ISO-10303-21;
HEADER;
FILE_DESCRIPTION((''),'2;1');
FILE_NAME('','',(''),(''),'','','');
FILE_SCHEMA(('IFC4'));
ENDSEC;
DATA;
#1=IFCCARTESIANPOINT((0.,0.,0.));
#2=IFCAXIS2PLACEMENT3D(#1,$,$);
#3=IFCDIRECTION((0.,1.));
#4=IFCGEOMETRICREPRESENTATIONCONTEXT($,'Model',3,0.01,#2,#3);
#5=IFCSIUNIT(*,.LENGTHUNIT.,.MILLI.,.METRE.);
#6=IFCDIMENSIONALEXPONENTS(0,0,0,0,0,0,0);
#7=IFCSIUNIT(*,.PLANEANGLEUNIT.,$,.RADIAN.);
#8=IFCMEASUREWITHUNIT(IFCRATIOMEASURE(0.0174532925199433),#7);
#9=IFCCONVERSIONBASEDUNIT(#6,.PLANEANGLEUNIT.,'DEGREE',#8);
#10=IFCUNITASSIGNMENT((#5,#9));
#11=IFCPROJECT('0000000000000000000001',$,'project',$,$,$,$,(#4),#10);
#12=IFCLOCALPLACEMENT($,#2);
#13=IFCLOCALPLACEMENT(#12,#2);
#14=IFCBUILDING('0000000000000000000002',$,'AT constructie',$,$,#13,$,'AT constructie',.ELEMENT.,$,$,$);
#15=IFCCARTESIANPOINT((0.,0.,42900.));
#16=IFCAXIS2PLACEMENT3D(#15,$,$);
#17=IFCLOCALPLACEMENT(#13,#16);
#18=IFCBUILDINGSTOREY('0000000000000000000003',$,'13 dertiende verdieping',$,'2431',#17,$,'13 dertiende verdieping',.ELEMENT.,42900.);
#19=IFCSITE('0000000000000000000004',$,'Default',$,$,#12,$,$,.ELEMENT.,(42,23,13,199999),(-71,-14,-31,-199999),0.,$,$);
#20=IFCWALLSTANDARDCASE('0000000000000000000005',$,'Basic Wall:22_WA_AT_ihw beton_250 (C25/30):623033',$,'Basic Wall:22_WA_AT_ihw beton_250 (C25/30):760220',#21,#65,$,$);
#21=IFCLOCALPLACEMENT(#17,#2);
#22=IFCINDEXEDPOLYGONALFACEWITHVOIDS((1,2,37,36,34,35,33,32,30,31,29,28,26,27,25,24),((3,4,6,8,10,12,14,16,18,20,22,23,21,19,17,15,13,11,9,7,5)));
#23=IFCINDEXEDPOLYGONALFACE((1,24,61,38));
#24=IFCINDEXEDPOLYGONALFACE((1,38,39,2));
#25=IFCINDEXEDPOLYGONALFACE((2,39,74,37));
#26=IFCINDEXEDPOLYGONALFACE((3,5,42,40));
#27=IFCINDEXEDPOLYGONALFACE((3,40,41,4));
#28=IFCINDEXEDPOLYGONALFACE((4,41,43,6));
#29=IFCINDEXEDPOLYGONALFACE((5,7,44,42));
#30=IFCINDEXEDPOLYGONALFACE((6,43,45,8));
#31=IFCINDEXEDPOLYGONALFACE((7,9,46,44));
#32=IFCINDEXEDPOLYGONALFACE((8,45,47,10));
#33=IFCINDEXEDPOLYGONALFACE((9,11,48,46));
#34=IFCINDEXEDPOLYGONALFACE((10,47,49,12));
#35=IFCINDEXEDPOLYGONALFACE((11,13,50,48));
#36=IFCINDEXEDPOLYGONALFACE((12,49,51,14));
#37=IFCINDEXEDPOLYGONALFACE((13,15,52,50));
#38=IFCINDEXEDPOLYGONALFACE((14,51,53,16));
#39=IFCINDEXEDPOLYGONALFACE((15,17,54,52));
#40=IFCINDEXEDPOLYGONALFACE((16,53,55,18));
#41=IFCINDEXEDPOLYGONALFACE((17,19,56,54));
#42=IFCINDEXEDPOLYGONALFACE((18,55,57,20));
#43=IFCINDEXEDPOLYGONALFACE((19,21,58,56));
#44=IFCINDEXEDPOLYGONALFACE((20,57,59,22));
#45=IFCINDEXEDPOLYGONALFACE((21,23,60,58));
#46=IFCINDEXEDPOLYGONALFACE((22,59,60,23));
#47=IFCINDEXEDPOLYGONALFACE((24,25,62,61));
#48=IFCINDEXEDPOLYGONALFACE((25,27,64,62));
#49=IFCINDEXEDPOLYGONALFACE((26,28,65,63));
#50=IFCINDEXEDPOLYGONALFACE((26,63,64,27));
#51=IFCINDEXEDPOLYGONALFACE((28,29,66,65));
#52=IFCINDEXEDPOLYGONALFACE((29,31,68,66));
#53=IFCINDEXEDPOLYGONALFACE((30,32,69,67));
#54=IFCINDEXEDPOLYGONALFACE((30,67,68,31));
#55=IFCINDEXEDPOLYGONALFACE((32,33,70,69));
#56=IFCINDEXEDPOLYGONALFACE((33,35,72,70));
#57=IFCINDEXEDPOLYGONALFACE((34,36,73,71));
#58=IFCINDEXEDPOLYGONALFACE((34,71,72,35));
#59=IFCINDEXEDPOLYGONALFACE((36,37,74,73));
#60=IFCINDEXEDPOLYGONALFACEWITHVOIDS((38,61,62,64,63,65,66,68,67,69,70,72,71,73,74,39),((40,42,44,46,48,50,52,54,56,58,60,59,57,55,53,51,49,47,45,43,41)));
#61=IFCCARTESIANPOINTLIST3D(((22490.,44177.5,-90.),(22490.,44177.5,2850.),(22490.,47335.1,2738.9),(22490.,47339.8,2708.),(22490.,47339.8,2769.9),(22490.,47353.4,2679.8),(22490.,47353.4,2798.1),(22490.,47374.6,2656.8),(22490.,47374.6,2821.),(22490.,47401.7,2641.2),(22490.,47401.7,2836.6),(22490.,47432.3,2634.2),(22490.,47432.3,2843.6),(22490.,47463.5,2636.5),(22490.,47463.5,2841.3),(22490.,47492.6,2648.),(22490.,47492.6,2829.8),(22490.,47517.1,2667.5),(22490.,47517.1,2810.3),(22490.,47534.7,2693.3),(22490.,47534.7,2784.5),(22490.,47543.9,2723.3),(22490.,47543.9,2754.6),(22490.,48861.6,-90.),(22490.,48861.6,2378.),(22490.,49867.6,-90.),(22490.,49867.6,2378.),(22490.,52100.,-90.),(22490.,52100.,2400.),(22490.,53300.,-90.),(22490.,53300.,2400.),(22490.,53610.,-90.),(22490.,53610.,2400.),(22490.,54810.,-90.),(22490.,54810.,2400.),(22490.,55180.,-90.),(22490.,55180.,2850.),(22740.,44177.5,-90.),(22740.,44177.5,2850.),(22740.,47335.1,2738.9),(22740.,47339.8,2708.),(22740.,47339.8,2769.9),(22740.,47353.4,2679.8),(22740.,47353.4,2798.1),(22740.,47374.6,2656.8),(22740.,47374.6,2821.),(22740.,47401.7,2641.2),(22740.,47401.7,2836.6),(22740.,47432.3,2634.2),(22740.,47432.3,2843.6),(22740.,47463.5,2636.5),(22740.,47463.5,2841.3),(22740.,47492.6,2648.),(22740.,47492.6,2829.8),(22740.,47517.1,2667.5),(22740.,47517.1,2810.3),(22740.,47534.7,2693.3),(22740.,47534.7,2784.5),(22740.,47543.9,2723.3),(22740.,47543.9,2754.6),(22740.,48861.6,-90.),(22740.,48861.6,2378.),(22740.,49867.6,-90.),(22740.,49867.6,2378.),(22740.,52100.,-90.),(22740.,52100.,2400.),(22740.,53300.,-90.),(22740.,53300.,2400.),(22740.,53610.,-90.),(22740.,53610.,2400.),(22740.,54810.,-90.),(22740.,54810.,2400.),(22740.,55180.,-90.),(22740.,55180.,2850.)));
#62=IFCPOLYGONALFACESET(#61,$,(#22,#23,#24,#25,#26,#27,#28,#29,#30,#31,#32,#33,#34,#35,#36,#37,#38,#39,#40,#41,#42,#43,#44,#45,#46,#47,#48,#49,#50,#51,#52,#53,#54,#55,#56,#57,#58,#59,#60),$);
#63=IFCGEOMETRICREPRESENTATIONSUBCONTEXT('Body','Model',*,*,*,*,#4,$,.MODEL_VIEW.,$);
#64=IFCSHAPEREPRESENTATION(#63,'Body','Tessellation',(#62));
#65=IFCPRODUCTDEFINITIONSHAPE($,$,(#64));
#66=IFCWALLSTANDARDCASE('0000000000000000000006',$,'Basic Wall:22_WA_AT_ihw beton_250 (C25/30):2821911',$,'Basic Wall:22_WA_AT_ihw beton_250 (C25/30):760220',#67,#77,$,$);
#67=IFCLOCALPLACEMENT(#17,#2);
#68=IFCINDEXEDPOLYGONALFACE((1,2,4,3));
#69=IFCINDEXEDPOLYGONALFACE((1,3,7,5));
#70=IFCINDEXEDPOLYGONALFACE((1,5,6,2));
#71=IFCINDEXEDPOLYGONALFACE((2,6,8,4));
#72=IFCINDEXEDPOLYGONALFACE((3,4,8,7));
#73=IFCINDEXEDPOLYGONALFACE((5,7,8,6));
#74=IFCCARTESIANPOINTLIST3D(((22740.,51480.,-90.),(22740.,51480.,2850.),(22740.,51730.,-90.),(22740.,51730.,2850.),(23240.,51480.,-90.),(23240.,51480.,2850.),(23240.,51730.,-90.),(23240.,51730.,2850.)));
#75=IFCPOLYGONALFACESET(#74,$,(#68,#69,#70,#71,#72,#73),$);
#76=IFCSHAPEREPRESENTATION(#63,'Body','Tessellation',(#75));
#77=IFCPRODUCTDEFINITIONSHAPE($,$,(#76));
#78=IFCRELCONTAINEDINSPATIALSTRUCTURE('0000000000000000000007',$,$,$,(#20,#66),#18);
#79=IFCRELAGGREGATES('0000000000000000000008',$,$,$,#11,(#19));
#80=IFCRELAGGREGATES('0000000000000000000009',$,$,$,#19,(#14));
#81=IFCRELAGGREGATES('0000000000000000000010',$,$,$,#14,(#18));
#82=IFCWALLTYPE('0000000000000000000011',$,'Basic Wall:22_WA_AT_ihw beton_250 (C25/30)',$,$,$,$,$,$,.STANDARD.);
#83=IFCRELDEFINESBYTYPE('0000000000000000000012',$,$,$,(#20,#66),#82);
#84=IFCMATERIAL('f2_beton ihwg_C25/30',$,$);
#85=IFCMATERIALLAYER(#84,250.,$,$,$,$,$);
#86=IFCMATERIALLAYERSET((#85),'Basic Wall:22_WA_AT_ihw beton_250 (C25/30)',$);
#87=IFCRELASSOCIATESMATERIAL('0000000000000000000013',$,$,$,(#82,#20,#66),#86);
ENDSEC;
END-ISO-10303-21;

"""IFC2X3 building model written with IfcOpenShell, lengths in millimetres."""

from ifc_helpers import new_model, entity, si_unit, converted_unit, direction, frame, frame_2d, origin, origin_2d_with_axis, place, context, subcontext, project, spatial, rectangle, circle, extrude, material, layer, layer_set, layer_usage, type_object, element, save


model = new_model("IFC2X3")

# Units and contexts
model_context = context("Model", 3, precision=0.01, world=origin(), true_north=direction((0.0, 1.0)))
body_context = subcontext(model_context, "Body", "Model", "MODEL_VIEW")
ifc_project = project(units=[si_unit("LENGTHUNIT", "METRE", prefix="MILLI"), converted_unit("PLANEANGLEUNIT", "DEGREE", entity("IfcRatioMeasure", 0.0174532925199433), si_unit("PLANEANGLEUNIT", "RADIAN"), dimensions=[0, 0, 0, 0, 0, 0, 0])], contexts=[model_context])

# Site, building, storey
site_placement = place(None, origin())
site = spatial("IfcSite", under=ifc_project, at=site_placement, Name="Default", CompositionType="ELEMENT", RefLatitude=(42, 23, 13, 199999), RefLongitude=(-71, -14, -31, -199999), RefElevation=0.0)
building_placement = place(site_placement, origin())
building = spatial("IfcBuilding", under=site, at=building_placement, Name="AT constructie", LongName="AT constructie", CompositionType="ELEMENT")
storey_placement = place(building_placement, frame((0.0, 0.0, 42900.0)))
storey = spatial("IfcBuildingStorey", under=building, at=storey_placement, Name="13 dertiende verdieping", ObjectType="2431", LongName="13 dertiende verdieping", CompositionType="ELEMENT", Elevation=42900.0)

# Shared definitions
ifc_material_1 = material(Name="f2_beton ihwg_C25/30")

# Wall, openings
ifc_layer_1 = layer(ifc_material_1, 250.0)
ifc_layer_set_1 = layer_set([ifc_layer_1], Name="Basic Wall:22_WA_AT_ihw beton_250 (C25/30)")
ifc_layer_usage_1 = layer_usage(ifc_layer_set_1, "AXIS2", "POSITIVE", -125.0)
wall_type_1 = type_object("IfcWallType", Name="Basic Wall:22_WA_AT_ihw beton_250 (C25/30)", PredefinedType="STANDARD", material=ifc_layer_set_1)
wall_1_placement = place(storey_placement, frame((22615.0, 55180.0, -90.0), z_axis=(0.0, 0.0, 1.0), x_axis=(0.0, -1.0, 0.0)))
wall_1 = element("IfcWallStandardCase", 1, at=wall_1_placement, inside=storey, type_object=wall_type_1, material=ifc_layer_usage_1, Name="Basic Wall:22_WA_AT_ihw beton_250 (C25/30):623033", ObjectType="Basic Wall:22_WA_AT_ihw beton_250 (C25/30):760220", context=body_context, shape_type="SweptSolid", body=[
    extrude(rectangle(XDim=11002.5, YDim=250.0, at=frame_2d((5501.2, 0.0), x_axis=(-1.0, 0.0))), origin(), (0.0, 0.0, 1.0), 2940.0),
])
opening_1_placement = place(wall_1_placement, origin())
element("IfcOpeningElement", 2, at=opening_1_placement, cuts=wall_1, ObjectType="Opening", context=body_context, shape_type="SweptSolid", body=[
    extrude(rectangle(XDim=2490.0, YDim=1200.0, at=frame_2d((0.0, 0.0), x_axis=(1.0, 0.0))), frame((970.0, -1399.0, 1245.0), z_axis=(0.0, 1.0, 0.0), x_axis=(0.0, 0.0, -1.0)), (0.0, 0.0, 1.0), 3048.0),
])
opening_2_placement = place(wall_1_placement, origin())
element("IfcOpeningElement", 3, at=opening_2_placement, cuts=wall_1, ObjectType="Opening", context=body_context, shape_type="SweptSolid", body=[
    extrude(rectangle(XDim=2490.0, YDim=1200.0, at=frame_2d((0.0, 0.0), x_axis=(1.0, 0.0))), frame((2480.0, -1399.0, 1245.0), z_axis=(0.0, 1.0, 0.0), x_axis=(0.0, 0.0, -1.0)), (0.0, 0.0, 1.0), 3048.0),
])
opening_3_placement = place(wall_1_placement, origin())
element("IfcOpeningElement", 4, at=opening_3_placement, cuts=wall_1, ObjectType="Opening", context=body_context, shape_type="SweptSolid", body=[
    extrude(rectangle(XDim=2468.0, YDim=1006.0, at=frame_2d((0.0, 0.0), x_axis=(1.0, 0.0))), frame((5815.4, -1399.0, 1234.0), z_axis=(0.0, 1.0, 0.0), x_axis=(0.0, 0.0, -1.0)), (0.0, 0.0, 1.0), 3048.0),
])
opening_4_placement = place(wall_1_placement, origin())
element("IfcOpeningElement", 5, at=opening_4_placement, cuts=wall_1, ObjectType="Opening", context=body_context, shape_type="SweptSolid", body=[
    extrude(circle(Radius=105.0, at=origin_2d_with_axis()), frame((7739.9, -125.0, 2828.9), z_axis=(0.0, 1.0, 0.0), x_axis=(1.0, 0.0, 0.0)), (0.0, 0.0, 1.0), 250.0),
])

# Wall
ifc_layer_usage_2 = layer_usage(ifc_layer_set_1, "AXIS2", "NEGATIVE", 125.0)
wall_2_placement = place(storey_placement, frame((23240.0, 51605.0, -90.0), z_axis=(0.0, 0.0, 1.0), x_axis=(-1.0, 0.0, 0.0)))
element("IfcWallStandardCase", 6, at=wall_2_placement, inside=storey, type_object=wall_type_1, material=ifc_layer_usage_2, Name="Basic Wall:22_WA_AT_ihw beton_250 (C25/30):2821911", ObjectType="Basic Wall:22_WA_AT_ihw beton_250 (C25/30):760220", context=body_context, shape_type="SweptSolid", body=[
    extrude(rectangle(XDim=500.0, YDim=250.0, at=frame_2d((250.0, 0.0), x_axis=(-1.0, 0.0))), origin(), (0.0, 0.0, 1.0), 2940.0),
])

save(model, "model.ifc")
